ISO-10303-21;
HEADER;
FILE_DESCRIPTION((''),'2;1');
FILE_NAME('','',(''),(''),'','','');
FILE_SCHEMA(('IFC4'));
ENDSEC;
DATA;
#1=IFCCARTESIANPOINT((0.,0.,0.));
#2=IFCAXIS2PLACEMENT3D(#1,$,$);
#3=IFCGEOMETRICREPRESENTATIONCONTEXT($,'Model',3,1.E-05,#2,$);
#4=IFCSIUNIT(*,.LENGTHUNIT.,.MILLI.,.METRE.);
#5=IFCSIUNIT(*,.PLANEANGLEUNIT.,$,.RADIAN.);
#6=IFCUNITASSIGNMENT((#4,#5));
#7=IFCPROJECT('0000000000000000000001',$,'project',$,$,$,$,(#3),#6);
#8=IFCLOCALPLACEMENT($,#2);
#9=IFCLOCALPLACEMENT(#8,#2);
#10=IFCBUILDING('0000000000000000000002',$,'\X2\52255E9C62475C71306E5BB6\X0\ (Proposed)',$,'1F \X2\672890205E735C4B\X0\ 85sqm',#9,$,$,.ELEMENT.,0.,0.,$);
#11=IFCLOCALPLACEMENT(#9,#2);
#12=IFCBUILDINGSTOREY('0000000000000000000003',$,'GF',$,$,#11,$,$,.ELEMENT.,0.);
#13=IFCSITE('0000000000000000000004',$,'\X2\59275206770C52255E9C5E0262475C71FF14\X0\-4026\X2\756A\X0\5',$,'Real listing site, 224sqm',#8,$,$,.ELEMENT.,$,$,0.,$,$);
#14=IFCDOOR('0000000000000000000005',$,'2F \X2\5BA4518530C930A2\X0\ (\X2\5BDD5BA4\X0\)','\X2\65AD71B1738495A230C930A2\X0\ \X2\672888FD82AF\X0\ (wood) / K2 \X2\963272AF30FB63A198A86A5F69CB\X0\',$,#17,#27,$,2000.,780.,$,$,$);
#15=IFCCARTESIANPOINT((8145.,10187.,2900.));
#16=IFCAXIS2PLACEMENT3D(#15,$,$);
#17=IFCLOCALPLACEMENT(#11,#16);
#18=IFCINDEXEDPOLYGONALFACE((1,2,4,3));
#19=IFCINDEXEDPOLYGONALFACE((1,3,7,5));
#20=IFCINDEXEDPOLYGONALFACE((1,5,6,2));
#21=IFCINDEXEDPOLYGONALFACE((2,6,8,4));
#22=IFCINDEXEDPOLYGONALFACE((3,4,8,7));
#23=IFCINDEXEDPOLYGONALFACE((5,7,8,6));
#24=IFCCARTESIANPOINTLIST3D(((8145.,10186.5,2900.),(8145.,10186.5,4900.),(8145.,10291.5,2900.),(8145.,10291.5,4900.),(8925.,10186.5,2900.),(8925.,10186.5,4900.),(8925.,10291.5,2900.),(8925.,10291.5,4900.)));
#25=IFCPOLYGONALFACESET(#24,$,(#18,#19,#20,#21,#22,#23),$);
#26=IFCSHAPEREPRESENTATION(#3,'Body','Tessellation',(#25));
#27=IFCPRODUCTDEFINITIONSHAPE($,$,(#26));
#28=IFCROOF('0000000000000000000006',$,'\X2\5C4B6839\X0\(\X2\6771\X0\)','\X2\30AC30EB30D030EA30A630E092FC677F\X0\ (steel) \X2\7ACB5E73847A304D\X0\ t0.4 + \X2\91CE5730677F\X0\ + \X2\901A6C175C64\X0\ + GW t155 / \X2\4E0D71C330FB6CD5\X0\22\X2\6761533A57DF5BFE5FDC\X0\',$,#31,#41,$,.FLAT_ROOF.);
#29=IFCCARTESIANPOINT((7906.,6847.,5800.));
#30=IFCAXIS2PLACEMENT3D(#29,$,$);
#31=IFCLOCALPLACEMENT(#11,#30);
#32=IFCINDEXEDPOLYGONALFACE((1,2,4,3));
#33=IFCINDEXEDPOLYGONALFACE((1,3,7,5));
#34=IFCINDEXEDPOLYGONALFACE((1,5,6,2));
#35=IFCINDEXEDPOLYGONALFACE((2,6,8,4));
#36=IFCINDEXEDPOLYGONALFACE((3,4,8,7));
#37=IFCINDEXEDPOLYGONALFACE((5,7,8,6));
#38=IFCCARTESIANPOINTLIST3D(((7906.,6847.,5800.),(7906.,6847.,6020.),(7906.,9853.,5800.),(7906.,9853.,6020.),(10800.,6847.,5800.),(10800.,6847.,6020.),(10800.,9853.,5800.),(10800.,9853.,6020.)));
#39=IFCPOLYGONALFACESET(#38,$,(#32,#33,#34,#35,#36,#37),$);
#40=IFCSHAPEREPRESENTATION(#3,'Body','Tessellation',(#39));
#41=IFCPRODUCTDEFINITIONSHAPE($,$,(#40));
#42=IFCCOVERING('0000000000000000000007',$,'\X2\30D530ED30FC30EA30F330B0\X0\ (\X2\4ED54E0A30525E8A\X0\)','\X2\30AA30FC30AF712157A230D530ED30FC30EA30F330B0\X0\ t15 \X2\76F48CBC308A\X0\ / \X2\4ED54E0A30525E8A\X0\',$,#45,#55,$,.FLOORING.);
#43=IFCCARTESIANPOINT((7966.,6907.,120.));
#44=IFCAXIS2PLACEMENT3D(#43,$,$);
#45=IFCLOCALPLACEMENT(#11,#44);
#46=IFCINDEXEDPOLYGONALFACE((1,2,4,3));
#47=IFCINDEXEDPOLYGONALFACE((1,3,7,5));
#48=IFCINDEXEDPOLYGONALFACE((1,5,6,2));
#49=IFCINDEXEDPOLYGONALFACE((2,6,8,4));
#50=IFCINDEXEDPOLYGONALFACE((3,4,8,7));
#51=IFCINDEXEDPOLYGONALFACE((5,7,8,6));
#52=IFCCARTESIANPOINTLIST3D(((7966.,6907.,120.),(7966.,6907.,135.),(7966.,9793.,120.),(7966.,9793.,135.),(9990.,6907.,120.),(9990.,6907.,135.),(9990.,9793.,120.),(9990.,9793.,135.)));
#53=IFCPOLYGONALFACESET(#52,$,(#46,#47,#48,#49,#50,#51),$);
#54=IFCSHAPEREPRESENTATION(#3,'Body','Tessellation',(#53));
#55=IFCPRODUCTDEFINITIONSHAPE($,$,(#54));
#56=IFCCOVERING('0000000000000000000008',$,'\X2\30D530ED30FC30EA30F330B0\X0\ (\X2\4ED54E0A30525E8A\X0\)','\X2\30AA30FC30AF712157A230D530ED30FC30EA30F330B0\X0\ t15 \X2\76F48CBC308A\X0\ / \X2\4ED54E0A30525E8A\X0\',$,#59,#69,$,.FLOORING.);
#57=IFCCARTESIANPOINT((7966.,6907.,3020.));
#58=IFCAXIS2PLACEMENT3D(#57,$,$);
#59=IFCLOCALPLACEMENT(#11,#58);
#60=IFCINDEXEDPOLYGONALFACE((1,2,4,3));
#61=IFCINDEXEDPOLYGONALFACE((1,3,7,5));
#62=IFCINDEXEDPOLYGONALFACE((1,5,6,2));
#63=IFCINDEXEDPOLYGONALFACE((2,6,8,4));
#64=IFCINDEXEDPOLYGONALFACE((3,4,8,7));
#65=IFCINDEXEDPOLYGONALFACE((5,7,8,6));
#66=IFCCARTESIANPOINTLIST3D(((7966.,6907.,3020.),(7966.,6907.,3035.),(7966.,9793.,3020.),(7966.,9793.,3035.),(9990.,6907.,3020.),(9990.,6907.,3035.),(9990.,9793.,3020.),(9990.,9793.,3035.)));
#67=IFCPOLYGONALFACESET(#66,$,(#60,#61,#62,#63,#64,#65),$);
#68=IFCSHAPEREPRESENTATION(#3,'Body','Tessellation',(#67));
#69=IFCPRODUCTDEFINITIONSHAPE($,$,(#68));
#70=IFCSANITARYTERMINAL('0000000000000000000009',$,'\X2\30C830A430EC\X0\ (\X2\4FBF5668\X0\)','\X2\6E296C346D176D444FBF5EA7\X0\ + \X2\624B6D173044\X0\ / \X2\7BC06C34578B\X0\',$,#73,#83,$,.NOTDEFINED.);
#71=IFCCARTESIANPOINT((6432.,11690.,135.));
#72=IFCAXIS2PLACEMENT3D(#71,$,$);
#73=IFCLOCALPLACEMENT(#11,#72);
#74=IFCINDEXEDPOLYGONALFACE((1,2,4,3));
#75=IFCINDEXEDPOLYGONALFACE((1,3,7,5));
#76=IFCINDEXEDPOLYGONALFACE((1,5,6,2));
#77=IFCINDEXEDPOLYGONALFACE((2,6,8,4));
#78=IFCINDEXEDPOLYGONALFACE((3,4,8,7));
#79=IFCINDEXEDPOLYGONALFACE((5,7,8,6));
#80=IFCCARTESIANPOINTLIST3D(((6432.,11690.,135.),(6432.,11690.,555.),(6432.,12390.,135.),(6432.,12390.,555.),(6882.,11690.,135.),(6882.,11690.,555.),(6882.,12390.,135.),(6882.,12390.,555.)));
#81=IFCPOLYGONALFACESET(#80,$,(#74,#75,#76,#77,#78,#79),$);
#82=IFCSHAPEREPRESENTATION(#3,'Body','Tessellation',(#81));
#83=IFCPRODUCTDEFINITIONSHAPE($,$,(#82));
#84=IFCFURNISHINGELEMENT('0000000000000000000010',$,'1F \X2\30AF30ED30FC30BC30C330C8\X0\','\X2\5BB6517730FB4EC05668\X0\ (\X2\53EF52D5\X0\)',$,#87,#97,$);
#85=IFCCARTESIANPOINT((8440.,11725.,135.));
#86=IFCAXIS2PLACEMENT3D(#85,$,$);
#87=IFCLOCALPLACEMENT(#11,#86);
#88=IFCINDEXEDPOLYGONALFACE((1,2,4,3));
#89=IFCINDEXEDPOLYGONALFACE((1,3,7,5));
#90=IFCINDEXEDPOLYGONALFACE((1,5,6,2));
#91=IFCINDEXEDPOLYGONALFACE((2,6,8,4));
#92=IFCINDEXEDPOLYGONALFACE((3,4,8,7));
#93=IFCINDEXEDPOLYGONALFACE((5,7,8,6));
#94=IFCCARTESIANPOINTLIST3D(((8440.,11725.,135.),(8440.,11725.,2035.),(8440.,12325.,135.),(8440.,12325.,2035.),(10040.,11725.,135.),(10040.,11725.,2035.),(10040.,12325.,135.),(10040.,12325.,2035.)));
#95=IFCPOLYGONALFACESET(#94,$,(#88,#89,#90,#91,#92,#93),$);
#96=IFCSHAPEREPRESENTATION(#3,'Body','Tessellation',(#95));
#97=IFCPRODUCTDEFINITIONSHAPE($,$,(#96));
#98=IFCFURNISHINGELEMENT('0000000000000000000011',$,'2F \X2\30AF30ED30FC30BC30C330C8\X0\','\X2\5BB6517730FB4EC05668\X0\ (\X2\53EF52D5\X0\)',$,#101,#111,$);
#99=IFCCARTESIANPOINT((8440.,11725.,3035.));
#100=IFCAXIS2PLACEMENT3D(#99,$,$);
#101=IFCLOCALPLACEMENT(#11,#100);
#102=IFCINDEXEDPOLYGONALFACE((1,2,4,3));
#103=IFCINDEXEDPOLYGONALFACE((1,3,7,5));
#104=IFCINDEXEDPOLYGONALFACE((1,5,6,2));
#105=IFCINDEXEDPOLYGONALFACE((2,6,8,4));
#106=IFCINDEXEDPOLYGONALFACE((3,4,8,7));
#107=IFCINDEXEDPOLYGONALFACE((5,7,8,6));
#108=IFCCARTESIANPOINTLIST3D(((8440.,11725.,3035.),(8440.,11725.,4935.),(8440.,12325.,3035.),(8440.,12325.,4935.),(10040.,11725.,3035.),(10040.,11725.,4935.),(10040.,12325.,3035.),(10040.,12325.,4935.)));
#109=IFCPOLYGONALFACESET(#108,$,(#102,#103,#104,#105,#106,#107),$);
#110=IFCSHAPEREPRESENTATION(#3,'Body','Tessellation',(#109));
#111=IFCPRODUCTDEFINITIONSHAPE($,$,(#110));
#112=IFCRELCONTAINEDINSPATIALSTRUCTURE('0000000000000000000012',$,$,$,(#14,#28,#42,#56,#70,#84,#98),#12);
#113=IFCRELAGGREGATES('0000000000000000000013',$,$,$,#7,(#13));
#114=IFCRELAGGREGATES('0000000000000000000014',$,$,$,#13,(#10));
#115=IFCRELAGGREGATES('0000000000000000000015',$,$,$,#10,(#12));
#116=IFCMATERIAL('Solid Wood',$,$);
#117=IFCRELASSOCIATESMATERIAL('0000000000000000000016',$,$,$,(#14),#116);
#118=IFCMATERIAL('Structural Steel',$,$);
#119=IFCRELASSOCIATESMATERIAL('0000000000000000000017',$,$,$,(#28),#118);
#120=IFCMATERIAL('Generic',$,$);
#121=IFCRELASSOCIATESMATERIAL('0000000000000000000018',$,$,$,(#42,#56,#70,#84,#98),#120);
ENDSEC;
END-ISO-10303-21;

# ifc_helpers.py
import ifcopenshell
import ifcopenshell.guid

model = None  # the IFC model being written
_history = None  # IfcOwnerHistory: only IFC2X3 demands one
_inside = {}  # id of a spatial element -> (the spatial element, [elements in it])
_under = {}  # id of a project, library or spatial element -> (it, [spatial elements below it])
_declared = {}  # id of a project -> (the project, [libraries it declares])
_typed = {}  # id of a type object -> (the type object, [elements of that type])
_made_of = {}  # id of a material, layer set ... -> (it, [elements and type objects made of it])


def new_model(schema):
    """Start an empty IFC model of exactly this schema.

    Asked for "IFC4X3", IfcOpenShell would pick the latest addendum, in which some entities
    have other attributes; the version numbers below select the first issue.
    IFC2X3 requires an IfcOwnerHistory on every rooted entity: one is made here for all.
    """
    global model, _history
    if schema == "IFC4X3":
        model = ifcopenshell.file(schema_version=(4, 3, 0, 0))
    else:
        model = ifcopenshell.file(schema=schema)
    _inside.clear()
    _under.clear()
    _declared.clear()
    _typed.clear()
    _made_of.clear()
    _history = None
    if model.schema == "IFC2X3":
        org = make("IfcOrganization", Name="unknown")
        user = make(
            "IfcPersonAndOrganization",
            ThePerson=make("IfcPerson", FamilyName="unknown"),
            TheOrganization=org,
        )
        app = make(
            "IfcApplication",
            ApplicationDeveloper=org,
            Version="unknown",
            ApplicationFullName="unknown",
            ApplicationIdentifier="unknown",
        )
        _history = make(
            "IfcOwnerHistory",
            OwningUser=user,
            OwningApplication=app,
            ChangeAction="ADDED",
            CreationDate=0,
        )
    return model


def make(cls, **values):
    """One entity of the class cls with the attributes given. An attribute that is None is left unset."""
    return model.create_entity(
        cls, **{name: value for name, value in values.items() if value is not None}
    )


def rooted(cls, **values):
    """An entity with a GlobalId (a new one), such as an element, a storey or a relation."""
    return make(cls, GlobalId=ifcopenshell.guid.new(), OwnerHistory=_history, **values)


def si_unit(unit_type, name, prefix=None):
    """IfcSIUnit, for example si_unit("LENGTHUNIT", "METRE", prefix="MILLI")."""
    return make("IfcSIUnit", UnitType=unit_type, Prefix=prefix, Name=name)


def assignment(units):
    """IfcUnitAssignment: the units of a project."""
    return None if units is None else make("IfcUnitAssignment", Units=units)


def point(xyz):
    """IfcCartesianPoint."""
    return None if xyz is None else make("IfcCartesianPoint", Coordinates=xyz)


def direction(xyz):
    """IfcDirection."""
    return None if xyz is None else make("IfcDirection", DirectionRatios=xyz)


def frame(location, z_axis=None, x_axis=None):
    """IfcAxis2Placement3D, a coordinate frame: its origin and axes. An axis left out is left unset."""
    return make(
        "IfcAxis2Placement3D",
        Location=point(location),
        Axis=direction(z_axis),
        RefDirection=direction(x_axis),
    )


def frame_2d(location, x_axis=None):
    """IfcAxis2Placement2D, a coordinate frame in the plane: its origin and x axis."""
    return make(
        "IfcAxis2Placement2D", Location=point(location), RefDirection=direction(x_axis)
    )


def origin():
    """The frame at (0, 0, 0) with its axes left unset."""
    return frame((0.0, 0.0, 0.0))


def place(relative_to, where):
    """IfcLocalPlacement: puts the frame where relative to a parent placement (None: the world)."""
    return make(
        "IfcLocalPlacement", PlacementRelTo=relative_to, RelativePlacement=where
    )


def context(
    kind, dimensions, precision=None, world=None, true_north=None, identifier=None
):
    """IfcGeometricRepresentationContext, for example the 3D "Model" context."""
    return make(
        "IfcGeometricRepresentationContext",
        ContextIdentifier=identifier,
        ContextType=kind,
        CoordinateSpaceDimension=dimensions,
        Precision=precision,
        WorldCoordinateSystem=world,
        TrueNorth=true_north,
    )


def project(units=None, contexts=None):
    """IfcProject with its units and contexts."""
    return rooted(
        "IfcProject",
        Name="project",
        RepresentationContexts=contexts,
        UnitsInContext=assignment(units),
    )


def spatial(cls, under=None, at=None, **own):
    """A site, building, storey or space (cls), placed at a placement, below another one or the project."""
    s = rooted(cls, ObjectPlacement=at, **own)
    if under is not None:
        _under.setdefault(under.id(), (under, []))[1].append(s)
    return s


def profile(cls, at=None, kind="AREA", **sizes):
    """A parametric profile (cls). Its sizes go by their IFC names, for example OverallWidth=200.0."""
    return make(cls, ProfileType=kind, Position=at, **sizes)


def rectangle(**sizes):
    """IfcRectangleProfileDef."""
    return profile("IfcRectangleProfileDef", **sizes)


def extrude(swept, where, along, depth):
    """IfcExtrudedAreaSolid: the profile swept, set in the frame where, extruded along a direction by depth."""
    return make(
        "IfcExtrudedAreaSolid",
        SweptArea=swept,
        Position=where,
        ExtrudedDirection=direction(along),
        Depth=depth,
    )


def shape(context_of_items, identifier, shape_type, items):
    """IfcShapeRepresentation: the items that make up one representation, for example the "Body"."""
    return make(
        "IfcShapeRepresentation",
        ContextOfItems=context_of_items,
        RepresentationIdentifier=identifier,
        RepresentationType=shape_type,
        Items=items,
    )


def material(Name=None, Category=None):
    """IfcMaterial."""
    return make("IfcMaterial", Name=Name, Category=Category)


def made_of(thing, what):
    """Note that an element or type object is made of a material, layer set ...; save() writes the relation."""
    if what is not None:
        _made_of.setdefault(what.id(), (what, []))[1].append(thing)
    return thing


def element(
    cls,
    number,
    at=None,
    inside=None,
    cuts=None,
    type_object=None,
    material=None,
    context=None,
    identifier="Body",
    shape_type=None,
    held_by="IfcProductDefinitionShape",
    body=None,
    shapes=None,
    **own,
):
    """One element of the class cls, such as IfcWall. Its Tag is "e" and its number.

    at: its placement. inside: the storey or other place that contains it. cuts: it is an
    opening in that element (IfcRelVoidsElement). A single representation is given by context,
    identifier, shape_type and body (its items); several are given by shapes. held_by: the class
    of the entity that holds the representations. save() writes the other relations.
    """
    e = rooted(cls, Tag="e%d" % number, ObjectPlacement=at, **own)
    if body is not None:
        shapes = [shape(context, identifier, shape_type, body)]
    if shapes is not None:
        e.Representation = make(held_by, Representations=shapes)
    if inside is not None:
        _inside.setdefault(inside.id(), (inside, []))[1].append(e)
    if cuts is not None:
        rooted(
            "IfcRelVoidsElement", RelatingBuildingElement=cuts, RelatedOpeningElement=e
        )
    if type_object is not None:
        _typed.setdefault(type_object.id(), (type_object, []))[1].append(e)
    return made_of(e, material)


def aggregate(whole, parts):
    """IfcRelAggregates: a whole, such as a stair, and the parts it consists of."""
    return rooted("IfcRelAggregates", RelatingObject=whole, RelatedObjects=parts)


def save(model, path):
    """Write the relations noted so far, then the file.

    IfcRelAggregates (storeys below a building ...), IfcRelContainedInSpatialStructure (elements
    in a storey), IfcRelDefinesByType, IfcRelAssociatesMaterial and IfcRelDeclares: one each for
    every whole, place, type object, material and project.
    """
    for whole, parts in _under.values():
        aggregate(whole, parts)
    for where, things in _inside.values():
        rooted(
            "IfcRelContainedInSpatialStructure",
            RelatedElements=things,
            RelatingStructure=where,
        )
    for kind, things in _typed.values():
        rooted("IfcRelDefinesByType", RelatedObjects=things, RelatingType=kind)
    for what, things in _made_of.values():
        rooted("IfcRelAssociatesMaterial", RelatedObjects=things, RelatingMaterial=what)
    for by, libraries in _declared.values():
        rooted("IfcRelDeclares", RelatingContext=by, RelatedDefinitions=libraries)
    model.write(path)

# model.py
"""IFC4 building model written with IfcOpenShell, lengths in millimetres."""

from ifc_helpers import new_model, si_unit, frame, frame_2d, origin, place, context, project, spatial, rectangle, extrude, material, element, save


model = new_model("IFC4")

# Units and contexts
model_context = context("Model", 3, precision=1e-05, world=origin())
ifc_project = project(units=[si_unit("LENGTHUNIT", "METRE", prefix="MILLI"), si_unit("PLANEANGLEUNIT", "RADIAN")], contexts=[model_context])

# Site, building, storey
site_placement = place(None, origin())
site = spatial("IfcSite", under=ifc_project, at=site_placement, Name="大分県別府市扇山４-4026番5", ObjectType="Real listing site, 224sqm", CompositionType="ELEMENT", RefElevation=0.0)
building_placement = place(site_placement, origin())
building = spatial("IfcBuilding", under=site, at=building_placement, Name="別府扇山の家 (Proposed)", ObjectType="1F 木造平屋 85sqm", CompositionType="ELEMENT", ElevationOfRefHeight=0.0, ElevationOfTerrain=0.0)
storey_placement = place(building_placement, origin())
storey = spatial("IfcBuildingStorey", under=building, at=storey_placement, Name="GF", CompositionType="ELEMENT", Elevation=0.0)

# Shared definitions
ifc_material_1 = material(Name="Solid Wood")

# Door
door_1_placement = place(storey_placement, frame((8145.0, 10187.0, 2900.0)))
element("IfcDoor", 1, at=door_1_placement, inside=storey, material=ifc_material_1, Name="2F 室内ドア (寝室)", Description="断熱玄関ドア 木製芯 (wood) / K2 防犯・採風機構", OverallHeight=2000.0, OverallWidth=780.0, context=model_context, shape_type="SweptSolid", body=[
    extrude(rectangle(XDim=780.0, YDim=105.0, at=frame_2d((390.0, 52.0))), frame((8145.0, 10187.0, 2900.0)), (0.0, 0.0, 1.0), 2000.0),
])

# Roof
ifc_material_2 = material(Name="Structural Steel")
roof_placement = place(storey_placement, frame((7906.0, 6847.0, 5800.0)))
element("IfcRoof", 2, at=roof_placement, inside=storey, material=ifc_material_2, Name="屋根(東)", Description="ガルバリウム鋼板 (steel) 立平葺き t0.4 + 野地板 + 通気層 + GW t155 / 不燃・法22条区域対応", PredefinedType="FLAT_ROOF", context=model_context, shape_type="SweptSolid", body=[
    extrude(rectangle(XDim=2894.0, YDim=3006.0, at=frame_2d((1447.0, 1503.0))), frame((7906.0, 6847.0, 5800.0)), (0.0, 0.0, 1.0), 220.0),
])

# Coverings
ifc_material_3 = material(Name="Generic")
covering_1_placement = place(storey_placement, frame((7966.0, 6907.0, 120.0)))
element("IfcCovering", 3, at=covering_1_placement, inside=storey, material=ifc_material_3, Name="フローリング (仕上げ床)", Description="オーク無垢フローリング t15 直貼り / 仕上げ床", PredefinedType="FLOORING", context=model_context, shape_type="SweptSolid", body=[
    extrude(rectangle(XDim=2024.0, YDim=2886.0, at=frame_2d((1012.0, 1443.0))), frame((7966.0, 6907.0, 120.0)), (0.0, 0.0, 1.0), 15.0),
])
covering_2_placement = place(storey_placement, frame((7966.0, 6907.0, 3020.0)))
element("IfcCovering", 4, at=covering_2_placement, inside=storey, material=ifc_material_3, Name="フローリング (仕上げ床)", Description="オーク無垢フローリング t15 直貼り / 仕上げ床", PredefinedType="FLOORING", context=model_context, shape_type="SweptSolid", body=[
    extrude(rectangle(XDim=2024.0, YDim=2886.0, at=frame_2d((1012.0, 1443.0))), frame((7966.0, 6907.0, 3020.0)), (0.0, 0.0, 1.0), 15.0),
])

# Sanitary terminal
sanitary_terminal_placement = place(storey_placement, frame((6432.0, 11690.0, 135.0)))
element("IfcSanitaryTerminal", 5, at=sanitary_terminal_placement, inside=storey, material=ifc_material_3, Name="トイレ (便器)", Description="温水洗浄便座 + 手洗い / 節水型", PredefinedType="NOTDEFINED", context=model_context, shape_type="SweptSolid", body=[
    extrude(rectangle(XDim=450.0, YDim=700.0, at=frame_2d((225.0, 350.0))), frame((6432.0, 11690.0, 135.0)), (0.0, 0.0, 1.0), 420.0),
])

# Furnishing elements
furnishing_1_placement = place(storey_placement, frame((8440.0, 11725.0, 135.0)))
element("IfcFurnishingElement", 6, at=furnishing_1_placement, inside=storey, material=ifc_material_3, Name="1F クローゼット", Description="家具・什器 (可動)", context=model_context, shape_type="SweptSolid", body=[
    extrude(rectangle(XDim=1600.0, YDim=600.0, at=frame_2d((800.0, 300.0))), frame((8440.0, 11725.0, 135.0)), (0.0, 0.0, 1.0), 1900.0),
])
furnishing_2_placement = place(storey_placement, frame((8440.0, 11725.0, 3035.0)))
element("IfcFurnishingElement", 7, at=furnishing_2_placement, inside=storey, material=ifc_material_3, Name="2F クローゼット", Description="家具・什器 (可動)", context=model_context, shape_type="SweptSolid", body=[
    extrude(rectangle(XDim=1600.0, YDim=600.0, at=frame_2d((800.0, 300.0))), frame((8440.0, 11725.0, 3035.0)), (0.0, 0.0, 1.0), 1900.0),
])

save(model, "model.ifc")
